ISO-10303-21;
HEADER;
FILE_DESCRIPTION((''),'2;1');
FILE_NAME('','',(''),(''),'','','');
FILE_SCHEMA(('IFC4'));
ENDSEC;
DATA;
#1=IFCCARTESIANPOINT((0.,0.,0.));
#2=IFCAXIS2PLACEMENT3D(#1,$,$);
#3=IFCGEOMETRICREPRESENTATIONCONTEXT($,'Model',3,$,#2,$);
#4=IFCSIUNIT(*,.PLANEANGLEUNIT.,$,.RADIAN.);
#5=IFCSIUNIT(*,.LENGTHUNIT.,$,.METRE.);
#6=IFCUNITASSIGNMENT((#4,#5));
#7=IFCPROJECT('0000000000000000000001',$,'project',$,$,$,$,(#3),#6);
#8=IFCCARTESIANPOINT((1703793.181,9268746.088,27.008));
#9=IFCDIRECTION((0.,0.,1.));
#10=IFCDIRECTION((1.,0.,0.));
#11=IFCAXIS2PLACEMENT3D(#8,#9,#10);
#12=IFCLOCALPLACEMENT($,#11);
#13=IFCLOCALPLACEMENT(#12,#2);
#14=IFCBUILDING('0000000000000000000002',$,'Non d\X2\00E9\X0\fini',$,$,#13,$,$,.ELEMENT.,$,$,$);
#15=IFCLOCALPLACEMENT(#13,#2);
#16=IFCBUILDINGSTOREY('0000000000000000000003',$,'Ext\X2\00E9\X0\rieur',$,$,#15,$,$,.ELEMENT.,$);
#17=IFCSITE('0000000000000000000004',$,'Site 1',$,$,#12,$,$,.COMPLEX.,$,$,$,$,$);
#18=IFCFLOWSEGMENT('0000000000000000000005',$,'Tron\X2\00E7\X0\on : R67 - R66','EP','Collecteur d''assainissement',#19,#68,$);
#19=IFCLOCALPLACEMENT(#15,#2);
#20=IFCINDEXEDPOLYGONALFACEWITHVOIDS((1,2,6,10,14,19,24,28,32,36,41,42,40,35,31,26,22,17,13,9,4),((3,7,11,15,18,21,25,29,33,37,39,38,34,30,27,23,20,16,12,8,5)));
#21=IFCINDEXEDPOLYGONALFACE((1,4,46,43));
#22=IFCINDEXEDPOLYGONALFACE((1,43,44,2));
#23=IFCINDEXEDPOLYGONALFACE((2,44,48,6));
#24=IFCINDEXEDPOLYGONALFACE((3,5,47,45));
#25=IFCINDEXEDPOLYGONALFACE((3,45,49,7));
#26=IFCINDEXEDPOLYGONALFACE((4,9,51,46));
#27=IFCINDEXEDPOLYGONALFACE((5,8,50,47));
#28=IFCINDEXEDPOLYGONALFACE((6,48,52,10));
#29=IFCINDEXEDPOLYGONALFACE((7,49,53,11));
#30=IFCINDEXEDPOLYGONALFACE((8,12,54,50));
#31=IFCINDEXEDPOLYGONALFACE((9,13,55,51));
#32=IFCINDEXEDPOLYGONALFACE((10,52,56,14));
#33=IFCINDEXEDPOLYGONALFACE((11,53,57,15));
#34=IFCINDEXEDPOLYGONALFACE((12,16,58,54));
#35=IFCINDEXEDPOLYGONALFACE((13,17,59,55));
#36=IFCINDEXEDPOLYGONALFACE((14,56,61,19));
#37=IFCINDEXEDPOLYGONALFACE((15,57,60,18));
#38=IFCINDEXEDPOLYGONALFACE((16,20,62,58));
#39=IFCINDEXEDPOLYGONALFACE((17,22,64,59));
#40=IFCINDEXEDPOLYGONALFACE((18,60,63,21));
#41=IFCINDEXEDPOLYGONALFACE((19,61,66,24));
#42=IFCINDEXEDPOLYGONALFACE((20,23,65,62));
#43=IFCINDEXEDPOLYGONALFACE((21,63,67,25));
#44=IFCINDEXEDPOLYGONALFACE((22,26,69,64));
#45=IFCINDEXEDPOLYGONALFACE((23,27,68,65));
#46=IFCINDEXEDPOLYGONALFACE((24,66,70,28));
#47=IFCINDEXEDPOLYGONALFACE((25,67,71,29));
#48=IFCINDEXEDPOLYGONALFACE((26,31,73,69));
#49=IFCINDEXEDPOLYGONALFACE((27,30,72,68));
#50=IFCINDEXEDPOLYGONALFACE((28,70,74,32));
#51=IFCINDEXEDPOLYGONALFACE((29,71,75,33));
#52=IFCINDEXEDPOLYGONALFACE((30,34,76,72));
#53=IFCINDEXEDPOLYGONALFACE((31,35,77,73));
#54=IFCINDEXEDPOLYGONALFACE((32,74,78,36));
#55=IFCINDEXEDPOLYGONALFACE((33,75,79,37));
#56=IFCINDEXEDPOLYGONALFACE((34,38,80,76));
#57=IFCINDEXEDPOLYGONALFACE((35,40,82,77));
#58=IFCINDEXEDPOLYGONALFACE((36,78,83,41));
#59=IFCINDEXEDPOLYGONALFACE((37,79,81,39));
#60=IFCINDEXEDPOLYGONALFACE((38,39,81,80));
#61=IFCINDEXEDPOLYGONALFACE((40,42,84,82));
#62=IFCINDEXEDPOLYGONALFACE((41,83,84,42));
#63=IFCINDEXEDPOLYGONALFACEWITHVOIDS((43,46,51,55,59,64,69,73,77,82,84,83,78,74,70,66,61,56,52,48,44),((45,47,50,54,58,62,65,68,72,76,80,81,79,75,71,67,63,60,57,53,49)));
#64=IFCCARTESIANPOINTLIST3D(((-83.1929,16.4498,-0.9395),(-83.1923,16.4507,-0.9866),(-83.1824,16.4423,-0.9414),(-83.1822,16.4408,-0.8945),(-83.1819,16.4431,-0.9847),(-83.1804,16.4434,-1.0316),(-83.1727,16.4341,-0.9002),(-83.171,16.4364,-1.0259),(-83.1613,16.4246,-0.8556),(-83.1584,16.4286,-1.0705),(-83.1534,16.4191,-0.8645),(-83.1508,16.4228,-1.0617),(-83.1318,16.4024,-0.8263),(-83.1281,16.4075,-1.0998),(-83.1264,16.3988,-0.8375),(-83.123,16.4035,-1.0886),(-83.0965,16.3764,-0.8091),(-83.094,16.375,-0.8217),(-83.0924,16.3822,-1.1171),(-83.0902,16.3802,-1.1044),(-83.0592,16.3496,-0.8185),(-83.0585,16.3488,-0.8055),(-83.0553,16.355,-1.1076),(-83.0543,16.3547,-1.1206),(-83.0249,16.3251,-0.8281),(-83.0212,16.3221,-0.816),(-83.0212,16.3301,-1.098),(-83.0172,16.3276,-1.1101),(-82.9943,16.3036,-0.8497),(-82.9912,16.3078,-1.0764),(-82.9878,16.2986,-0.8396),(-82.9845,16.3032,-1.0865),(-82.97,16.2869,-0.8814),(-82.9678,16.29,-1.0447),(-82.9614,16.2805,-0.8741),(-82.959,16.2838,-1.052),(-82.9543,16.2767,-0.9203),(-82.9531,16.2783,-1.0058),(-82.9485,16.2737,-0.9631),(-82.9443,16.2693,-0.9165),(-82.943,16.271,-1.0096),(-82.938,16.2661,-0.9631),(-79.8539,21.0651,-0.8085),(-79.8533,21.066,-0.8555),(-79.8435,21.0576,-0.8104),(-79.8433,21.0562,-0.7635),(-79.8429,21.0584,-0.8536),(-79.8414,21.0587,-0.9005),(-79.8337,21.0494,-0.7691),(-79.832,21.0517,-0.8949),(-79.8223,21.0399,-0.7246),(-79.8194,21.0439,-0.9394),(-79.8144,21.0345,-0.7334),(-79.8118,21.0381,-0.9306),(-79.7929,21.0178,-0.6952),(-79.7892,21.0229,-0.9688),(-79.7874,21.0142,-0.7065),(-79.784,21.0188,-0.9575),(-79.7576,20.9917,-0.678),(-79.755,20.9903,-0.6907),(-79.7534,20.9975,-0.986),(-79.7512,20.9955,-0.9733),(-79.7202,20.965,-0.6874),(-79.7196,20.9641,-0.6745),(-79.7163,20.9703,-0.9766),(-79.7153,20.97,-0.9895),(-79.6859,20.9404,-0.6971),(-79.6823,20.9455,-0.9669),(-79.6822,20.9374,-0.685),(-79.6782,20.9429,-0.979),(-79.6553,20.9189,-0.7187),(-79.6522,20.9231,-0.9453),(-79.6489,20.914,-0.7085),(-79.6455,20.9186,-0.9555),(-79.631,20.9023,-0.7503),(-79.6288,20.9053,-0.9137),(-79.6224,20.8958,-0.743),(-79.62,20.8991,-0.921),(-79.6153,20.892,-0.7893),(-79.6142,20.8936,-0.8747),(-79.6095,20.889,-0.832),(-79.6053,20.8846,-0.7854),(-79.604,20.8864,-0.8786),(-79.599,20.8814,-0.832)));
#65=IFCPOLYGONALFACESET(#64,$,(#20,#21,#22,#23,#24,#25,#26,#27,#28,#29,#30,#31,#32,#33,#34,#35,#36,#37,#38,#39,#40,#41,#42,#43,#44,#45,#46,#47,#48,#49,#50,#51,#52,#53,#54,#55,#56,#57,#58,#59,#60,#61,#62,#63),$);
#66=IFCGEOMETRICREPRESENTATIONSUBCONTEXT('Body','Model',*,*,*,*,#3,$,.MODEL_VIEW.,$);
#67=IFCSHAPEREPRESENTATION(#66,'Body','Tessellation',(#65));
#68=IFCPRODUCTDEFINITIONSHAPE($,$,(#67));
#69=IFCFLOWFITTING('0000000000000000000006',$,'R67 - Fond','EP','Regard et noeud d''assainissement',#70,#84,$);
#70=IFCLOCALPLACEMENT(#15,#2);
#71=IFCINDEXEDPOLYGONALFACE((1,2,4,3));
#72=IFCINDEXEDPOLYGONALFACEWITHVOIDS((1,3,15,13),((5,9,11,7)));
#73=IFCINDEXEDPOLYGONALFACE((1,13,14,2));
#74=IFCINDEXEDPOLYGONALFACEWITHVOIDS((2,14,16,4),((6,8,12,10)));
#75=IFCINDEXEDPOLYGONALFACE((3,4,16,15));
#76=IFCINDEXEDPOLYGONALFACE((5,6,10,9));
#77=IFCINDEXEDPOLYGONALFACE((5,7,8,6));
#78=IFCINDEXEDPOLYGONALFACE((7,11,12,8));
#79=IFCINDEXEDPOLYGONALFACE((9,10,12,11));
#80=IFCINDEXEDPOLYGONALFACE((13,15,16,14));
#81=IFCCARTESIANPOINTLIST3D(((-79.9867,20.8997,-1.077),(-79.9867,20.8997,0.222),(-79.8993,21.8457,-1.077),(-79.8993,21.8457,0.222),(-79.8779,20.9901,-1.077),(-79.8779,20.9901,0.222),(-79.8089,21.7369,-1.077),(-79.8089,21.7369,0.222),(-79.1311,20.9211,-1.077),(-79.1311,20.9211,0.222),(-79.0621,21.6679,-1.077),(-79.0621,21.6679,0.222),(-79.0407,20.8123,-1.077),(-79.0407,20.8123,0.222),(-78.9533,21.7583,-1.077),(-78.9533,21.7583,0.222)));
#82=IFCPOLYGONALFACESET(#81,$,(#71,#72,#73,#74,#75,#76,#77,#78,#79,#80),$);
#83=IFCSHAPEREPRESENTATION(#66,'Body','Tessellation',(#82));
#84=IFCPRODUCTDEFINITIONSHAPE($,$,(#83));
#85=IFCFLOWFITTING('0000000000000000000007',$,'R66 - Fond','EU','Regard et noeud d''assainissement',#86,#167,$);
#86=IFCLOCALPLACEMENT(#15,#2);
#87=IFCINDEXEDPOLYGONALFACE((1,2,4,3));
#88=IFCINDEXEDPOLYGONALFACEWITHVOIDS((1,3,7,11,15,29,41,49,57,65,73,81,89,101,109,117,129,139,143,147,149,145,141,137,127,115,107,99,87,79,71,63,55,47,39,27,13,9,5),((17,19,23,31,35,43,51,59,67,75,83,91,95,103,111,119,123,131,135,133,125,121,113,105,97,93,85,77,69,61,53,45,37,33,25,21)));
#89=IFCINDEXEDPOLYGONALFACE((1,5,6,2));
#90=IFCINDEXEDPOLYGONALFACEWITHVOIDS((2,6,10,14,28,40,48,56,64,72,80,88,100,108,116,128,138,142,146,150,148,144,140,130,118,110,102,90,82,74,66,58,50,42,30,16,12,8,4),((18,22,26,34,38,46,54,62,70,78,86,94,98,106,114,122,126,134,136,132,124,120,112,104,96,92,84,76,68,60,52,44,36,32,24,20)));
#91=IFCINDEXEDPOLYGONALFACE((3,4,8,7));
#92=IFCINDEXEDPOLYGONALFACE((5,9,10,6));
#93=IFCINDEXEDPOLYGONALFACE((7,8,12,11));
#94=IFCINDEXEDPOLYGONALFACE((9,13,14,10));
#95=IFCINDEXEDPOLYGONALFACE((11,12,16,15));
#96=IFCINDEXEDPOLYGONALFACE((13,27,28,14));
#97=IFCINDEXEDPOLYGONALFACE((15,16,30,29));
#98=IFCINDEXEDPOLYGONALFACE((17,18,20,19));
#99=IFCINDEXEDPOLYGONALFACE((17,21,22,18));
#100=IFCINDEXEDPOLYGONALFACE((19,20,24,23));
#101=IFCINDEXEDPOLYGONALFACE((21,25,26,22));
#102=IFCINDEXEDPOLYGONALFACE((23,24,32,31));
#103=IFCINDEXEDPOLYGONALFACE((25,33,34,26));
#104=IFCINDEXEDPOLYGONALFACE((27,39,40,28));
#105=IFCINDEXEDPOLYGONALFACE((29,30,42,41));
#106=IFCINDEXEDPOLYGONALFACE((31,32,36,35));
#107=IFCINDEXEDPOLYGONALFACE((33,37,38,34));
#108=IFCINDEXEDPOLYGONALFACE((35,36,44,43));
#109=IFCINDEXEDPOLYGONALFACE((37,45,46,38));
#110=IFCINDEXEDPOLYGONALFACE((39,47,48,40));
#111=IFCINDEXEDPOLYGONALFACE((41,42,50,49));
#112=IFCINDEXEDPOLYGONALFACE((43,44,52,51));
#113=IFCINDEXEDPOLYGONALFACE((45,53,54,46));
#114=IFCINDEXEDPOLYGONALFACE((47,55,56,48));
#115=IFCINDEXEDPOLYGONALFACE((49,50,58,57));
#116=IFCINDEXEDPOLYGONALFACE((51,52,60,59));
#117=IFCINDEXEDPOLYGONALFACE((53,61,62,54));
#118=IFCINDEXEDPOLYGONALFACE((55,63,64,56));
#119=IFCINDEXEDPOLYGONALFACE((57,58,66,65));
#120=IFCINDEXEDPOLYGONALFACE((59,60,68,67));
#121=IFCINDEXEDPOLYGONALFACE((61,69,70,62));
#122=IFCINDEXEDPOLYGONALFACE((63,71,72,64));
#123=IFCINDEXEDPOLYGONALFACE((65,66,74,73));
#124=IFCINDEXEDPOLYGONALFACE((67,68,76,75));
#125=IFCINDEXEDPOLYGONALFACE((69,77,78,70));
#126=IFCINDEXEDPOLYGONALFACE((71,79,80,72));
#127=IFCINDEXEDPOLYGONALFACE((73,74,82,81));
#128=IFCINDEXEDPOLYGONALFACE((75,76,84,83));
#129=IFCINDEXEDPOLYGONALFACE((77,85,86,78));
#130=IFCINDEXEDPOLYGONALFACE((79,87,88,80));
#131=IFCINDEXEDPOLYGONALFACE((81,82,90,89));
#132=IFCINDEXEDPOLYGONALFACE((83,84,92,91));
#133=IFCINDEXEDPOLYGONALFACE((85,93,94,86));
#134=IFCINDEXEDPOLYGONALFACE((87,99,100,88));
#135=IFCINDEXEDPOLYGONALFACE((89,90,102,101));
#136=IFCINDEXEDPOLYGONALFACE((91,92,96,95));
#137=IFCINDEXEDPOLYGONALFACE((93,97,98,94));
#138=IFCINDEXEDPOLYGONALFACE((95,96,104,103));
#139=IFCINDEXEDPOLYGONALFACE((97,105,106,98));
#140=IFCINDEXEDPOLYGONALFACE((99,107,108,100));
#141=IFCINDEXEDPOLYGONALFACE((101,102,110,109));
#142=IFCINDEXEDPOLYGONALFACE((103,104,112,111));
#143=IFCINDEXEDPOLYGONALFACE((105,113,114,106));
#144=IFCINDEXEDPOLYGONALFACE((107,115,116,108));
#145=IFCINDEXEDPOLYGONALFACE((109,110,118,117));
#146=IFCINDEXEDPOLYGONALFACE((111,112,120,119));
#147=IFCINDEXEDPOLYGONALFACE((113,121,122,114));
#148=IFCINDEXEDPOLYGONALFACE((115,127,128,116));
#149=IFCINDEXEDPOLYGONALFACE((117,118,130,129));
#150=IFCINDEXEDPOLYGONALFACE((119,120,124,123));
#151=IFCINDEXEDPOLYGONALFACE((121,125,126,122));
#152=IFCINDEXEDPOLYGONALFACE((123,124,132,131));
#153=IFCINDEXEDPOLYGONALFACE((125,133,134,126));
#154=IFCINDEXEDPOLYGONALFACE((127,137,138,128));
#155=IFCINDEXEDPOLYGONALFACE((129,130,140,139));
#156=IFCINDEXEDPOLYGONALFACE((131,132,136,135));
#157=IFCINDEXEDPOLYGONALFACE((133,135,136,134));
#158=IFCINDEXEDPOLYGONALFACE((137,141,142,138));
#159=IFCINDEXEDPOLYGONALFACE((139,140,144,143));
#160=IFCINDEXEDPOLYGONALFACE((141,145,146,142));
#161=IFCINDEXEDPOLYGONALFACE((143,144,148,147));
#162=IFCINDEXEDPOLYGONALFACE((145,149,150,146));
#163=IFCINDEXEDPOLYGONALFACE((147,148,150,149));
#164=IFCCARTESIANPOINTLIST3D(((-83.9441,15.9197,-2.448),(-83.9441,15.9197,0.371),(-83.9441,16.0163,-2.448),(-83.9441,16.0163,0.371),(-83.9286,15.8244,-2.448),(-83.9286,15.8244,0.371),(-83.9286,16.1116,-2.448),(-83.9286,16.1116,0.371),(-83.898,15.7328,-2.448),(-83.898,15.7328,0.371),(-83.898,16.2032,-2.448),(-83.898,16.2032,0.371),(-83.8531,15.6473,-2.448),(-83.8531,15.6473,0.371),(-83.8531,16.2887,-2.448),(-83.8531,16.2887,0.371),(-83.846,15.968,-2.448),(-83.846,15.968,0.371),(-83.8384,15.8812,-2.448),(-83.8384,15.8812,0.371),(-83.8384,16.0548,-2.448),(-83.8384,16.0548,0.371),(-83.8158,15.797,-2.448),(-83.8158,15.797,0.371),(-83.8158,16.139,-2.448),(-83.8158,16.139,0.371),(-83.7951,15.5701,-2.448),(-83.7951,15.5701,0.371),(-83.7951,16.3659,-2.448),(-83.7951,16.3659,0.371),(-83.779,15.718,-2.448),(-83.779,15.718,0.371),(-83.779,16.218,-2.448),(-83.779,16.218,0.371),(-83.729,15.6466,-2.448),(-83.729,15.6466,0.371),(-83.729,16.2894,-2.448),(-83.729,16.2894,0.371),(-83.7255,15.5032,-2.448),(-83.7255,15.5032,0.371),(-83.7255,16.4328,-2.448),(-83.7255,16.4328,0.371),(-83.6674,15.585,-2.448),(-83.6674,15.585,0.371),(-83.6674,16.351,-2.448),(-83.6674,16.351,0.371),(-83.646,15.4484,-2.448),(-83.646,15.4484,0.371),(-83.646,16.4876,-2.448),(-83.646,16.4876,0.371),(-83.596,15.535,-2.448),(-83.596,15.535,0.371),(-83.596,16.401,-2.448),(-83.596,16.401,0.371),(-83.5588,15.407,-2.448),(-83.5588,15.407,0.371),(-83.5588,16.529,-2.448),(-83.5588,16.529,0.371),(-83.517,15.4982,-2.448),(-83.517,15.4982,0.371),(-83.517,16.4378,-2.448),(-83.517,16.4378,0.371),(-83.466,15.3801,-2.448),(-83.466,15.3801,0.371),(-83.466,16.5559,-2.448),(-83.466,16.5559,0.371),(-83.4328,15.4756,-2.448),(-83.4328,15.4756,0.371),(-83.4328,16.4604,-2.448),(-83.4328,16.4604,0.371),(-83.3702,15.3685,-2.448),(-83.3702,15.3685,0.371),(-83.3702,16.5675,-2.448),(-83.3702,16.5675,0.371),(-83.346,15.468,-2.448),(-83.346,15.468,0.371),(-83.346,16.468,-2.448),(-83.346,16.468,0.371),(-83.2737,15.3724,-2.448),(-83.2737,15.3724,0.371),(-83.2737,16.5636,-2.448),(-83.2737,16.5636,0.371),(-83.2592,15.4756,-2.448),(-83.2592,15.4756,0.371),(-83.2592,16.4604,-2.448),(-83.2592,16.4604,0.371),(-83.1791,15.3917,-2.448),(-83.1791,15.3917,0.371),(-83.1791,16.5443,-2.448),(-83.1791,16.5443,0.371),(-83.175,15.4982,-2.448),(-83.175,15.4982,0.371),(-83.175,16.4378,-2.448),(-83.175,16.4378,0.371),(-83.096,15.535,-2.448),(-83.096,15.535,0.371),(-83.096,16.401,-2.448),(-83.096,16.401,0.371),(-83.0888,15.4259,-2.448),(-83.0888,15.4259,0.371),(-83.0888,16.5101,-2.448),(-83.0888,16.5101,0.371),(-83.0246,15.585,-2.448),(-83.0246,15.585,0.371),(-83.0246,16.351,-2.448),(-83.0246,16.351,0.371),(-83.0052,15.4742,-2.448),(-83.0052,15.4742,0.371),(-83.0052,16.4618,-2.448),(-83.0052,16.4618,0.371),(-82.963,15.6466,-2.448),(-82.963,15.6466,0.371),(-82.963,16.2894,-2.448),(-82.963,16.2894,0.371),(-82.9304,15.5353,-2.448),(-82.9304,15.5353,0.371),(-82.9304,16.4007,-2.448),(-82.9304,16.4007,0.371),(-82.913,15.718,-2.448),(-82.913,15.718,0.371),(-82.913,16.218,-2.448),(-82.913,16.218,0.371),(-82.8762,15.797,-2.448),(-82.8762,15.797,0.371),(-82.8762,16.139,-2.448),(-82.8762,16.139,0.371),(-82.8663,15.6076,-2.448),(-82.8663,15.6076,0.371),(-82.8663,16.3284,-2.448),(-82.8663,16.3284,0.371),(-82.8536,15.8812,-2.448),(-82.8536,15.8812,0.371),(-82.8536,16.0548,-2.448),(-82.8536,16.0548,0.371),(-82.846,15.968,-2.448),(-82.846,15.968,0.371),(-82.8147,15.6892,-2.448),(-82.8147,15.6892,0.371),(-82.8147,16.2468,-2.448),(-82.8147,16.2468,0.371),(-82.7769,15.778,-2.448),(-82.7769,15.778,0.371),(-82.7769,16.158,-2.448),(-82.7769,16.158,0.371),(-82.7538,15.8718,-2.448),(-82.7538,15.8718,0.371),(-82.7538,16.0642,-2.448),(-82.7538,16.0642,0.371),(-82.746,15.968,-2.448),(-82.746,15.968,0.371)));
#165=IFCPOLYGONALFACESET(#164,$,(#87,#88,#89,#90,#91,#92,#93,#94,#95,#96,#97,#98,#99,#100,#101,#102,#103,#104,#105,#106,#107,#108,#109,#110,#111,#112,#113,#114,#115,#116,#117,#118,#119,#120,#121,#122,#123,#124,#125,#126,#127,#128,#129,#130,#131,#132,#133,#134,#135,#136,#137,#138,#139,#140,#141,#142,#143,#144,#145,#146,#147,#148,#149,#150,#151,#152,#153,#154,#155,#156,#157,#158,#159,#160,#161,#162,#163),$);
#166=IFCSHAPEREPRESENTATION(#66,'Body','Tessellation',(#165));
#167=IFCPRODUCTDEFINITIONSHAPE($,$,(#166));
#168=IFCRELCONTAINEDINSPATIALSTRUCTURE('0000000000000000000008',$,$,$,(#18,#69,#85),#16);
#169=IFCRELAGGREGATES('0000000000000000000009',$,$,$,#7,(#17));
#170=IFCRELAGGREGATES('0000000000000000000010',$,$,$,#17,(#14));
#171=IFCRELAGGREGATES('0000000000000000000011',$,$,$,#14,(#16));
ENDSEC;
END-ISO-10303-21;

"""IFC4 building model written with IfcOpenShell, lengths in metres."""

from ifc_helpers import new_model, si_unit, frame, origin, origin_2d, place, context, subcontext, project, spatial, hollow_rectangle, hollow_circle, extrude, element, save


model = new_model("IFC4")

# Units and contexts
model_context = context("Model", 3, world=origin())
body_context = subcontext(model_context, "Body", "Model", "MODEL_VIEW")
ifc_project = project(units=[si_unit("PLANEANGLEUNIT", "RADIAN"), si_unit("LENGTHUNIT", "METRE")], contexts=[model_context])

# Site, building, storey
site_placement = place(None, frame((1703793.181, 9268746.088, 27.008), z_axis=(0.0, 0.0, 1.0), x_axis=(1.0, 0.0, 0.0)))
site = spatial("IfcSite", under=ifc_project, at=site_placement, Name="Site 1", CompositionType="COMPLEX")
building_placement = place(site_placement, origin())
building = spatial("IfcBuilding", under=site, at=building_placement, Name="Non défini", CompositionType="ELEMENT")
storey_placement = place(building_placement, origin())
storey = spatial("IfcBuildingStorey", under=building, at=storey_placement, Name="Extérieur", CompositionType="ELEMENT")

# Flow segment
flow_segment_1_placement = place(storey_placement, origin())
element("IfcFlowSegment", 1, at=flow_segment_1_placement, inside=storey, Name="Tronçon : R67 - R66", Description="EP", ObjectType="Collecteur d'assainissement", context=body_context, shape_type="SweptSolid", body=[
    extrude(hollow_circle(Radius=0.158, WallThickness=0.013, at=origin_2d()), frame((-79.727, 20.974, -0.832), z_axis=(-0.586, -0.81, -0.023), x_axis=(0.81, -0.586, 0.0)), (0.0, 0.0, 1.0), 5.698),
])

# Flow fittings
flow_fitting_1_placement = place(storey_placement, origin())
element("IfcFlowFitting", 2, at=flow_fitting_1_placement, inside=storey, Name="R67 - Fond", Description="EP", ObjectType="Regard et noeud d'assainissement", context=body_context, shape_type="SweptSolid", body=[
    extrude(hollow_rectangle(XDim=0.95, YDim=0.95, WallThickness=0.1, at=origin_2d()), frame((-79.47, 21.329, -1.077), z_axis=(0.0, 0.0, 1.0), x_axis=(0.092, 0.996, 0.0)), (0.0, 0.0, 1.0), 1.299),
])
flow_fitting_2_placement = place(storey_placement, origin())
element("IfcFlowFitting", 3, at=flow_fitting_2_placement, inside=storey, Name="R66 - Fond", Description="EU", ObjectType="Regard et noeud d'assainissement", context=body_context, shape_type="SweptSolid", body=[
    extrude(hollow_circle(Radius=0.6, WallThickness=0.1, at=origin_2d()), frame((-83.346, 15.968, -2.448), z_axis=(0.0, 0.0, 1.0), x_axis=(1.0, 0.0, 0.0)), (0.0, 0.0, 1.0), 2.819),
])

save(model, "model.ifc")
